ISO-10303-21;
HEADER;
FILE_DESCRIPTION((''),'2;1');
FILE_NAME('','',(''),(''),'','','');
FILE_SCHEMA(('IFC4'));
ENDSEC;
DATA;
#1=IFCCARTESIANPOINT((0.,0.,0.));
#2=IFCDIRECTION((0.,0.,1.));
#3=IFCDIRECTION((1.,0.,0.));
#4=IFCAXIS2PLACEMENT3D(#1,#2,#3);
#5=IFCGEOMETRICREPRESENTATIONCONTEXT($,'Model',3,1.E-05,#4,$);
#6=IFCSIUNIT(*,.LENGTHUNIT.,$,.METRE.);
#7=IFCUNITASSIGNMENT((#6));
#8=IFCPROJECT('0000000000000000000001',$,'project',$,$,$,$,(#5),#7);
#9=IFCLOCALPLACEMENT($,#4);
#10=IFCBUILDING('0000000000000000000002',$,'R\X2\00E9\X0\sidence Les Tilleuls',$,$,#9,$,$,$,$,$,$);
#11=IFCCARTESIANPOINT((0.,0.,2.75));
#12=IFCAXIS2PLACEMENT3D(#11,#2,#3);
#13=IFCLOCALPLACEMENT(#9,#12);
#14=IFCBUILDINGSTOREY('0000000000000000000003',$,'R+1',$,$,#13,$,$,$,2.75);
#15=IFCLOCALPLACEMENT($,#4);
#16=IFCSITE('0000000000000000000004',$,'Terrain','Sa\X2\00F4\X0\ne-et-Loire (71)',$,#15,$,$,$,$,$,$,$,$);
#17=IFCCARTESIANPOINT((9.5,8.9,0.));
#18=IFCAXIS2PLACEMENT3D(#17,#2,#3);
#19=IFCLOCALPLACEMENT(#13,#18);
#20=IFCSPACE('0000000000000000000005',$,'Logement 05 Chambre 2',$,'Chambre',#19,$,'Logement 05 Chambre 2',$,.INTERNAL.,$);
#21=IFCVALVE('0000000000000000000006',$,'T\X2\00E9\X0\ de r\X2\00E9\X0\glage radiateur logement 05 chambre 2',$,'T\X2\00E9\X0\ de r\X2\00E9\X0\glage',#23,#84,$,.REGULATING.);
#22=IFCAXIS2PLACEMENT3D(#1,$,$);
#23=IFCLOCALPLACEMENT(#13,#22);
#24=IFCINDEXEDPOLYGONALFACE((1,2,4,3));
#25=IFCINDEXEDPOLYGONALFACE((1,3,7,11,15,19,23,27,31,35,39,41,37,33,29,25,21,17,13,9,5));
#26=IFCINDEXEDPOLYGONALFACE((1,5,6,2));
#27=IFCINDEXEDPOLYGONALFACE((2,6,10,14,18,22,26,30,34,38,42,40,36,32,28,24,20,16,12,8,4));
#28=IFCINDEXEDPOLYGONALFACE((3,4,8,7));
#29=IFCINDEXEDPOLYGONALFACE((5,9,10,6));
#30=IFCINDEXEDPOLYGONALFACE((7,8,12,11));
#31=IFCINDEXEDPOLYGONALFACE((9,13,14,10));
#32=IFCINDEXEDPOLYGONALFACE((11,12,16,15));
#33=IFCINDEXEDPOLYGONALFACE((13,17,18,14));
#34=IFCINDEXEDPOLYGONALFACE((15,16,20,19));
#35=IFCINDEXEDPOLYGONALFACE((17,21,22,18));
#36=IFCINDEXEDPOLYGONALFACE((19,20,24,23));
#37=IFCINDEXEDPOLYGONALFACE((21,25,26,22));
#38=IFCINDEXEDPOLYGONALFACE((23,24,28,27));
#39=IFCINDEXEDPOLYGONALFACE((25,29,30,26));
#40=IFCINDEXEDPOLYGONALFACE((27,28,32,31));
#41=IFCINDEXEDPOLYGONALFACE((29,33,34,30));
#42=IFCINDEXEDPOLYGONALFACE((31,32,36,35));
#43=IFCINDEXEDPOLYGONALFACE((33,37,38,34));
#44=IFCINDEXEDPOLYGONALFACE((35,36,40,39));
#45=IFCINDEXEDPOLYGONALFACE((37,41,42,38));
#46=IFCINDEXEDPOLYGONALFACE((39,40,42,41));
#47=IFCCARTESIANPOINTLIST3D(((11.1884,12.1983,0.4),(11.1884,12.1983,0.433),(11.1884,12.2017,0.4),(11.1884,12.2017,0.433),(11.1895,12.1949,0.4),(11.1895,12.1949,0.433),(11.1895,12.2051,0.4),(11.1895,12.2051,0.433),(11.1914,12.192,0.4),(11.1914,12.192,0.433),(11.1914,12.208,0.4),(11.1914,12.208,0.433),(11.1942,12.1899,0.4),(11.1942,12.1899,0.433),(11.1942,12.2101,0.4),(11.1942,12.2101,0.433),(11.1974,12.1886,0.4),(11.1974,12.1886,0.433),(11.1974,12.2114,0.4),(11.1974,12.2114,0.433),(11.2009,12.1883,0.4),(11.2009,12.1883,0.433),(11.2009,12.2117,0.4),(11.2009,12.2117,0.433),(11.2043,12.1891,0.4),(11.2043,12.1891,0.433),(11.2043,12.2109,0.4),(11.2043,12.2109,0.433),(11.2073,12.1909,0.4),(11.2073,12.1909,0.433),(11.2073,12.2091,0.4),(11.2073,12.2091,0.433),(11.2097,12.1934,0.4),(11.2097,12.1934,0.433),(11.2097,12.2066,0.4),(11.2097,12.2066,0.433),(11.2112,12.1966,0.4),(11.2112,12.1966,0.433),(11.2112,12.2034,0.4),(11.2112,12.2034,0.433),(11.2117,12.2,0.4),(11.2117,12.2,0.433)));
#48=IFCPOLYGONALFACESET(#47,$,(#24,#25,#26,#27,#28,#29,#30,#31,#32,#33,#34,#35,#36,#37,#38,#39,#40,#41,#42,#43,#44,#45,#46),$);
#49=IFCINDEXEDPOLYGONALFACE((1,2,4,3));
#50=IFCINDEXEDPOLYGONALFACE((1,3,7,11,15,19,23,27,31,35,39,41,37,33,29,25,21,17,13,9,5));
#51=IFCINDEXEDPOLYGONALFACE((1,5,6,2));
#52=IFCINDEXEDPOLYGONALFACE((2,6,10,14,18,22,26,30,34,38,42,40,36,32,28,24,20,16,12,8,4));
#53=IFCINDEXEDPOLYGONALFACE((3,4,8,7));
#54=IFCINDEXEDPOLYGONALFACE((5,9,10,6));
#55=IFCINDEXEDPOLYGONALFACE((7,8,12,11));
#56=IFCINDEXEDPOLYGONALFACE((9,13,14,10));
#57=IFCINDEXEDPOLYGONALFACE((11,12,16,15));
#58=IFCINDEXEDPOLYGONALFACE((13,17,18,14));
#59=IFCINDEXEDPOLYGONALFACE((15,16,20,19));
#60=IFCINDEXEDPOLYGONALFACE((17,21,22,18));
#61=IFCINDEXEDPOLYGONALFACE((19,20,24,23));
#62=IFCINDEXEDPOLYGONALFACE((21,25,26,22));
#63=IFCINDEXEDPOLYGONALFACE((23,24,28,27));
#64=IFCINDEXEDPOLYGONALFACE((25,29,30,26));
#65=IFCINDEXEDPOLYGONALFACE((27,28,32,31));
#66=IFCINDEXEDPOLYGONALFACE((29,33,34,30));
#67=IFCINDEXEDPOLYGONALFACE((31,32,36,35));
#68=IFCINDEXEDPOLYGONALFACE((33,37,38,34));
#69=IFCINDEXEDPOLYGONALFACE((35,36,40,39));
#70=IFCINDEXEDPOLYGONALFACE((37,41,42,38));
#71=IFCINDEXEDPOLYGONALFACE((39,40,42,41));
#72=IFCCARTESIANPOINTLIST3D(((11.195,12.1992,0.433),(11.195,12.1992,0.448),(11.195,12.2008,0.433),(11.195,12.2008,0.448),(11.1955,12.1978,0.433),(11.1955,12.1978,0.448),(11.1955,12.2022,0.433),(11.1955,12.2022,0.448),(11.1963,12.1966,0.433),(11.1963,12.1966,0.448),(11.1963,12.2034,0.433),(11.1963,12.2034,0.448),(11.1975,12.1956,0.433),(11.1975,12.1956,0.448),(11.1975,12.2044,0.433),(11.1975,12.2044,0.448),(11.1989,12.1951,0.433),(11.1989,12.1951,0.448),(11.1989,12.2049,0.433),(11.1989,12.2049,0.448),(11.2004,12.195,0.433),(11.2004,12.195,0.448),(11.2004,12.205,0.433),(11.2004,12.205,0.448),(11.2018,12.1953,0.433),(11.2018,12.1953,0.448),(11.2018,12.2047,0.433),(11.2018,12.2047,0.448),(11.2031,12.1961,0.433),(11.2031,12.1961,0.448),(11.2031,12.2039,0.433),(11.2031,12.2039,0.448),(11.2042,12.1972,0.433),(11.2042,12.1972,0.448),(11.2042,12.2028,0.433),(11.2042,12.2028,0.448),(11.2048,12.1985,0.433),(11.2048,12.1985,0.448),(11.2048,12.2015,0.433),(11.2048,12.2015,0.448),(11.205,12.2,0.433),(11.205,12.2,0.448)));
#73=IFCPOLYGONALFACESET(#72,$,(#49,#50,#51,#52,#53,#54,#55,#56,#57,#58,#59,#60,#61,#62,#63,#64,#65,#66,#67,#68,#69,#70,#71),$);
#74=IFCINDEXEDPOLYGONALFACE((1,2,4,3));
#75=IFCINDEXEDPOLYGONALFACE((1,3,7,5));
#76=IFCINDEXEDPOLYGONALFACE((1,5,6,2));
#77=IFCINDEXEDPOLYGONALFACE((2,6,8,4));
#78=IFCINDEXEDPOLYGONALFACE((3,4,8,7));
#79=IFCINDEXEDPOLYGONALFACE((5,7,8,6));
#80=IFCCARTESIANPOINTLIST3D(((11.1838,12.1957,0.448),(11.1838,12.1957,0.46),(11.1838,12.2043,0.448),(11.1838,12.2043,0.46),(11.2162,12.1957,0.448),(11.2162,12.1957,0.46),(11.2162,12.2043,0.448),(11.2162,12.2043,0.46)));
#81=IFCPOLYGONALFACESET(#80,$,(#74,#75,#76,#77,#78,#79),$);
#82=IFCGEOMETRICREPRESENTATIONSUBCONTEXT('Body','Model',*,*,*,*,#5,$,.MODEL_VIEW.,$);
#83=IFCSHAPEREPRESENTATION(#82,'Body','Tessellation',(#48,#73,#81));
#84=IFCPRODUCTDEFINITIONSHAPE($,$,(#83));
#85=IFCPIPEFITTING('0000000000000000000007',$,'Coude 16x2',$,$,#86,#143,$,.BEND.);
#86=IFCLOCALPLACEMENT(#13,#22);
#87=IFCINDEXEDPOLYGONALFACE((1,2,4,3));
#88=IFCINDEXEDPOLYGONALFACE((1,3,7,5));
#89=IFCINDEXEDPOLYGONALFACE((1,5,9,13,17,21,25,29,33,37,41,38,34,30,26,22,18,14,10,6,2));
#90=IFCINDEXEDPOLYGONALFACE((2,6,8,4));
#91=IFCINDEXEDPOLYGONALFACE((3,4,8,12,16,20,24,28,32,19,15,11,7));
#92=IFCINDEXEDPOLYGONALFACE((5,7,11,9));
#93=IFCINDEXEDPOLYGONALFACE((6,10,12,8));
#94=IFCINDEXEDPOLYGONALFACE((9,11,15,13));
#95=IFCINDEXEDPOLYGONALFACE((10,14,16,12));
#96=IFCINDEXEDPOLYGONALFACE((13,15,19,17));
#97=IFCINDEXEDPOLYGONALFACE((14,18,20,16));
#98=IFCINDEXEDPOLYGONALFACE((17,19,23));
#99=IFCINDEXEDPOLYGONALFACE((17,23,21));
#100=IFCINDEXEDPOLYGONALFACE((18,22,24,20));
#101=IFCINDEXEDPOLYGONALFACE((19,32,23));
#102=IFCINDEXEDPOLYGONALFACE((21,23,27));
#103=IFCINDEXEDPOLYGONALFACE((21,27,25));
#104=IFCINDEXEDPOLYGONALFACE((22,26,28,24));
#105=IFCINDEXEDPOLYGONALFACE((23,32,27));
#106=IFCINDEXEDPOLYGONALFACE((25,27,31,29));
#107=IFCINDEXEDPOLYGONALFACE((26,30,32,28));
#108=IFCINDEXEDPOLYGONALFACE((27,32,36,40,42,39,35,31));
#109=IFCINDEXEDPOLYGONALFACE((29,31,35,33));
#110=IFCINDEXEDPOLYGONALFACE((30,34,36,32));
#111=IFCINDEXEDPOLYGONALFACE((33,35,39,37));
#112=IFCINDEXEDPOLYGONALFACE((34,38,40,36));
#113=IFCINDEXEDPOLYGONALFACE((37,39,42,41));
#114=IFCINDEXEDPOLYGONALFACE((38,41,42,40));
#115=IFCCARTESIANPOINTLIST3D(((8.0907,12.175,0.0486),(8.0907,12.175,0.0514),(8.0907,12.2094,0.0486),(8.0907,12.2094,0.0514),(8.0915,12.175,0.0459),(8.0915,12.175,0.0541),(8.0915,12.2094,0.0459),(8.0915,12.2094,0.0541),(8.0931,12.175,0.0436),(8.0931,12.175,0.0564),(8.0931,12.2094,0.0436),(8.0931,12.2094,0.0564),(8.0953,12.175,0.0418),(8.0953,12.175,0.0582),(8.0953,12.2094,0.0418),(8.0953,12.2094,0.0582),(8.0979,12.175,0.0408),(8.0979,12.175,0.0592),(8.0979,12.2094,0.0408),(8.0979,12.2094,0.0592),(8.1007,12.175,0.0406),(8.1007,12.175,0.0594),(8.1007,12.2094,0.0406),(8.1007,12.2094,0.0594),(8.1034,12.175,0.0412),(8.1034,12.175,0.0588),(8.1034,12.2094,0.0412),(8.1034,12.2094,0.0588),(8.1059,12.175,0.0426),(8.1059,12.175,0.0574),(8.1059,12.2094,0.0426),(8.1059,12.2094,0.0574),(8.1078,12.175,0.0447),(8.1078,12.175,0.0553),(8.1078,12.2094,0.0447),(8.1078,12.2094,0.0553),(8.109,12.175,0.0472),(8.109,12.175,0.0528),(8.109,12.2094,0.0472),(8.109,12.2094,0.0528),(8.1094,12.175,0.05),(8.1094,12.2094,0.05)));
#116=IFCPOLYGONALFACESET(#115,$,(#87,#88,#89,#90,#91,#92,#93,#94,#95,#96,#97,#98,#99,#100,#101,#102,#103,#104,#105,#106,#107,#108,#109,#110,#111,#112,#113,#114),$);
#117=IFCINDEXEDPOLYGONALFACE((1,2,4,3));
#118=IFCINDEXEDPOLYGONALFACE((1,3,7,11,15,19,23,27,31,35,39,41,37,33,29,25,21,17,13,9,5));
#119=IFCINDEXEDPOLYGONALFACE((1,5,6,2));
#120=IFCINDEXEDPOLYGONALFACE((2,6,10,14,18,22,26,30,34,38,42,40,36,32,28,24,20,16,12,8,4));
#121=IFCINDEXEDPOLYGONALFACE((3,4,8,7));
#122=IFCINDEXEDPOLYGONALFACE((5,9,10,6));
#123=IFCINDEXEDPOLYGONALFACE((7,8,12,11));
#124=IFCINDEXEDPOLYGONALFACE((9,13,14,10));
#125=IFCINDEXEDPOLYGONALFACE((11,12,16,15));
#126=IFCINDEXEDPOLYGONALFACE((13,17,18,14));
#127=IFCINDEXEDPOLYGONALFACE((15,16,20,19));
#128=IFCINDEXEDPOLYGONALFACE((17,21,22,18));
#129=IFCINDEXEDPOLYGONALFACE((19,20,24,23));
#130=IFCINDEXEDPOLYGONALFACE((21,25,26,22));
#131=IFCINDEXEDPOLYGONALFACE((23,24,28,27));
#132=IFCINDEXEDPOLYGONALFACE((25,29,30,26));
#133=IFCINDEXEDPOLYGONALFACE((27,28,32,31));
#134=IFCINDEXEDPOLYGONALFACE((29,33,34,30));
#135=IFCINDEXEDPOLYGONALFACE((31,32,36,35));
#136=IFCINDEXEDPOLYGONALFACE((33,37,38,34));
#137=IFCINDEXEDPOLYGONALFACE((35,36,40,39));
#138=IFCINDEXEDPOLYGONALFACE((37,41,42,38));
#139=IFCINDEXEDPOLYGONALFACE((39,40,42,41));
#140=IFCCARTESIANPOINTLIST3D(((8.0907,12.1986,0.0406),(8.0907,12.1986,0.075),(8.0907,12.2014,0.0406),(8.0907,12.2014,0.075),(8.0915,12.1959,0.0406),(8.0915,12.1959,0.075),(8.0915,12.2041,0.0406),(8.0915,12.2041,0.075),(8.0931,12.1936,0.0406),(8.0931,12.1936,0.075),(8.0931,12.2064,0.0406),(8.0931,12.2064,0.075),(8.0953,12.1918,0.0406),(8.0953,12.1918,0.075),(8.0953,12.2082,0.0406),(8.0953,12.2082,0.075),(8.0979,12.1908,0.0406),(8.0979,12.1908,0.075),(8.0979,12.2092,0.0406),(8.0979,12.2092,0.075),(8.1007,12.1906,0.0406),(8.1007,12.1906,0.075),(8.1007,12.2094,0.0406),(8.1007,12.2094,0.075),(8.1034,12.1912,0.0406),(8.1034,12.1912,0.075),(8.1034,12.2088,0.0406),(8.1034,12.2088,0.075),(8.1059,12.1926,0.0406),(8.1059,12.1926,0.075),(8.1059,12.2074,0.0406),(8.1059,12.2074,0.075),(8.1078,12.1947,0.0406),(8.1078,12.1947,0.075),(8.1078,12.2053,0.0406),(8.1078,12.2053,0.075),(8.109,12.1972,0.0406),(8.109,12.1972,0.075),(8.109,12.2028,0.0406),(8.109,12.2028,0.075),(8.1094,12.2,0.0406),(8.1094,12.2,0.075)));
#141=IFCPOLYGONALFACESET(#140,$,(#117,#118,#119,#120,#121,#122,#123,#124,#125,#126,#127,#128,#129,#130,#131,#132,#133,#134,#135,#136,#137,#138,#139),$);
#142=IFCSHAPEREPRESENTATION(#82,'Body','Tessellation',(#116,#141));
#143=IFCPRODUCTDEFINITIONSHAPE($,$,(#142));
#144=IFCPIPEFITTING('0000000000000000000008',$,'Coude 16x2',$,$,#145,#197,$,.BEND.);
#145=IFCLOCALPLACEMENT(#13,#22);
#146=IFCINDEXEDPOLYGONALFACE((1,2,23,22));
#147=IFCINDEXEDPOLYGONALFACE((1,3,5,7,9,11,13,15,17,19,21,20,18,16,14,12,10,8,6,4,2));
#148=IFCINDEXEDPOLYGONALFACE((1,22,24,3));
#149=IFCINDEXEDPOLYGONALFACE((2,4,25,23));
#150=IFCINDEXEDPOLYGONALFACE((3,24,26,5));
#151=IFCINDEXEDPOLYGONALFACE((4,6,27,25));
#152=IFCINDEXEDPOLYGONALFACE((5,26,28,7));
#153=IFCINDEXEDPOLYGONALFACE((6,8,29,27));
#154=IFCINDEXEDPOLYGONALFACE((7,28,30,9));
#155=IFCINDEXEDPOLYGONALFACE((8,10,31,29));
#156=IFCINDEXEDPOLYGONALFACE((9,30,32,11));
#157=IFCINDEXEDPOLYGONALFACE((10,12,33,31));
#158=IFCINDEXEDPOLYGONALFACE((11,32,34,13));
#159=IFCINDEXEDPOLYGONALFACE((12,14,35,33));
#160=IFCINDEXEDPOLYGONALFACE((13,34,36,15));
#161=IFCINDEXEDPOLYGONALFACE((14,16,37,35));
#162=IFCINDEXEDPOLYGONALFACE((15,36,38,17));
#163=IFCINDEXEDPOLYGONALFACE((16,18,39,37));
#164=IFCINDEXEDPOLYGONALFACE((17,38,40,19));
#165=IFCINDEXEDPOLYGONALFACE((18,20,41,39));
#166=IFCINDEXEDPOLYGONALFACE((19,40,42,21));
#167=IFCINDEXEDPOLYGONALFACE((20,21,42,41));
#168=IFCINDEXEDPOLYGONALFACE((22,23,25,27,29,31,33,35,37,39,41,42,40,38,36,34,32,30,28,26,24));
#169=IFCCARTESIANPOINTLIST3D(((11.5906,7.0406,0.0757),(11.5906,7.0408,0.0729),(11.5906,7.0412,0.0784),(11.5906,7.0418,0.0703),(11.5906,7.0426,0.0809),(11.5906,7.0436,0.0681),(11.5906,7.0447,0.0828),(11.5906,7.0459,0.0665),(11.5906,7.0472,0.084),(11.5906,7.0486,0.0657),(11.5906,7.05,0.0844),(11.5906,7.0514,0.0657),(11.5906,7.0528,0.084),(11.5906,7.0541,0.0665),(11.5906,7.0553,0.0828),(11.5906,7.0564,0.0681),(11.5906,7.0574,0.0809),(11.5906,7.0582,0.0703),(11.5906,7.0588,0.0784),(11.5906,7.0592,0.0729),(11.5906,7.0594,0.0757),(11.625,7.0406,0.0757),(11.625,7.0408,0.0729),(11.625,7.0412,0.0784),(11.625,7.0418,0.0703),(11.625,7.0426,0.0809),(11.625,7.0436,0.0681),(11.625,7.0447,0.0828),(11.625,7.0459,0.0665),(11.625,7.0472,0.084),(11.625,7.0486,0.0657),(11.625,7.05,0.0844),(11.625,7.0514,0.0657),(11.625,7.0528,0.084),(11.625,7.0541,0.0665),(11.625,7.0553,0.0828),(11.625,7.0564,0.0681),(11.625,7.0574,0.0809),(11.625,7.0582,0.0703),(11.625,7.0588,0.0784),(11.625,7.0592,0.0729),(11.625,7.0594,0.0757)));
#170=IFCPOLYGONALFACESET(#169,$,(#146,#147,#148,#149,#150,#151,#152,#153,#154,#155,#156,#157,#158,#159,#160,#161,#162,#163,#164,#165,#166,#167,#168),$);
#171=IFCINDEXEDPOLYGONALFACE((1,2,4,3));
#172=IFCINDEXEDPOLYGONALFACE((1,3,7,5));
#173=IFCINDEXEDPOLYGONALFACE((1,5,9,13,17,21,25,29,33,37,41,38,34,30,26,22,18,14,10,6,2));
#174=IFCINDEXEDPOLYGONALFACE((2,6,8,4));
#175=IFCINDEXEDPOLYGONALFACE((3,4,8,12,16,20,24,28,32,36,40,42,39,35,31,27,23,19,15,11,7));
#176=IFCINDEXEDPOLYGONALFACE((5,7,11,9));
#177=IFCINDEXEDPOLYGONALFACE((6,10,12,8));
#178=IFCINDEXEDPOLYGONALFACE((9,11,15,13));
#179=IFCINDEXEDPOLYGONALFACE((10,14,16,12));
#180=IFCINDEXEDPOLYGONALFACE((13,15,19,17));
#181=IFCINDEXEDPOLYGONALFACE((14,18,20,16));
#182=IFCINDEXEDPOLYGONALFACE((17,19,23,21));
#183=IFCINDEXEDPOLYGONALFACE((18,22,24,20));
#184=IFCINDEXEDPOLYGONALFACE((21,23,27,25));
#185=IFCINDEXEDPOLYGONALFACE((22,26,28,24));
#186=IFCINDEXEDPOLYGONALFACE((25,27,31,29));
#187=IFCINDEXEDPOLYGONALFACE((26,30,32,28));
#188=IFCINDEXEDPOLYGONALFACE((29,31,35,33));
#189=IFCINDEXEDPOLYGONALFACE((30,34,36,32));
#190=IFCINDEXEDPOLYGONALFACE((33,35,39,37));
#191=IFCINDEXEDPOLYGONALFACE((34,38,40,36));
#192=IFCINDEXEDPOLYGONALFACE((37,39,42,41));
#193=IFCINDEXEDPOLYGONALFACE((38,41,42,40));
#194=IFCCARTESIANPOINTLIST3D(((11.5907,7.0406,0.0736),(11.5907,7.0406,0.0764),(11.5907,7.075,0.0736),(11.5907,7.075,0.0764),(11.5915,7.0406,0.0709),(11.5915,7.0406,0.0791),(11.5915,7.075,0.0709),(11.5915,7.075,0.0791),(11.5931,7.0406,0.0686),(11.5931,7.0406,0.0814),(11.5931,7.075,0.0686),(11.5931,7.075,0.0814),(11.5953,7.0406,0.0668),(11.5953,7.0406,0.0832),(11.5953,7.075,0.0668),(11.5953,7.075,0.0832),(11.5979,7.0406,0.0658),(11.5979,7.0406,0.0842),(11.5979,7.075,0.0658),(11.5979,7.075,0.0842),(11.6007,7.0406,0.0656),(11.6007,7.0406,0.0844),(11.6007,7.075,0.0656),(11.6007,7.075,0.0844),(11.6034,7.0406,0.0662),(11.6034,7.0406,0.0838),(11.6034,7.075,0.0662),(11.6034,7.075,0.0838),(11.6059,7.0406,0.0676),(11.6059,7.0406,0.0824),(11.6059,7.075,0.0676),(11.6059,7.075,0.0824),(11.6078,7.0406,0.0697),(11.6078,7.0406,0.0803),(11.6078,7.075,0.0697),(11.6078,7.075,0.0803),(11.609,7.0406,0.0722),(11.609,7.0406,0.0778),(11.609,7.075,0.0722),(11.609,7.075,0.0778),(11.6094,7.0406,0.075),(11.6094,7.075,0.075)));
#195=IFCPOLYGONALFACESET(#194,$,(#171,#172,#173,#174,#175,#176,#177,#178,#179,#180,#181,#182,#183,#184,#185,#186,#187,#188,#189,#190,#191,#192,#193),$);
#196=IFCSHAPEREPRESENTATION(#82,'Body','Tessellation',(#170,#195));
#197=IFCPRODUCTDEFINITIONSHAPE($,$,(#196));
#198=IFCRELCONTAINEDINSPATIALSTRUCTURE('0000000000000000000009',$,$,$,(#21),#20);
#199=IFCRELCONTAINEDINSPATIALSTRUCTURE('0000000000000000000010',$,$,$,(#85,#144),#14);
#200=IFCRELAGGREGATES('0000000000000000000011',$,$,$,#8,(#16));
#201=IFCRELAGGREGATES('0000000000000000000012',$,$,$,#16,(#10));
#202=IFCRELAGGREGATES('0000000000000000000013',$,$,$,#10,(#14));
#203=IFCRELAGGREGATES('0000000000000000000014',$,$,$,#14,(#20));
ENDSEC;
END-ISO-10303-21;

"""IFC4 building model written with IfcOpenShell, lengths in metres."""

from ifc_helpers import new_model, si_unit, frame, frame_2d, origin_with_axes, place, context, subcontext, project, spatial, rectangle, circle, extrude, element, save


model = new_model("IFC4")

# Units and contexts
model_context = context("Model", 3, precision=1e-05, world=origin_with_axes())
body_context = subcontext(model_context, "Body", "Model", "MODEL_VIEW")
ifc_project = project(units=[si_unit("LENGTHUNIT", "METRE")], contexts=[model_context])

# Site, building, storey
site_placement = place(None, origin_with_axes())
site = spatial("IfcSite", under=ifc_project, at=site_placement, Name="Terrain", Description="Saône-et-Loire (71)")
building_placement = place(None, origin_with_axes())
building = spatial("IfcBuilding", under=site, at=building_placement, Name="Résidence Les Tilleuls")
storey_placement = place(building_placement, frame((0.0, 0.0, 2.75), z_axis=(0.0, 0.0, 1.0), x_axis=(1.0, 0.0, 0.0)))
storey = spatial("IfcBuildingStorey", under=building, at=storey_placement, Name="R+1", Elevation=2.75)

# Shared definitions
space_1_placement = place(storey_placement, frame((9.5, 8.9, 0.0), z_axis=(0.0, 0.0, 1.0), x_axis=(1.0, 0.0, 0.0)))
space_1 = spatial("IfcSpace", under=storey, at=space_1_placement, Name="Logement 05 Chambre 2", ObjectType="Chambre", LongName="Logement 05 Chambre 2", PredefinedType="INTERNAL")

# Valve
valve_1_placement = place(space_1_placement, frame((1.7, 3.3, 0.4), z_axis=(0.0, 0.0, 1.0), x_axis=(1.0, 0.0, 0.0)))
element("IfcValve", 1, at=valve_1_placement, inside=space_1, Name="Té de réglage radiateur logement 05 chambre 2", ObjectType="Té de réglage", PredefinedType="REGULATING", context=body_context, shape_type="SweptSolid", body=[
    extrude(circle(Radius=0.0117), origin_with_axes(), (0.0, 0.0, 1.0), 0.033),
    extrude(circle(Radius=0.005), frame((0.0, 0.0, 0.033), z_axis=(0.0, 0.0, 1.0), x_axis=(1.0, 0.0, 0.0)), (0.0, 0.0, 1.0), 0.015),
    extrude(rectangle(XDim=0.0324, YDim=0.0086, at=frame_2d((0.0162, 0.0043))), frame((-0.0162, -0.0043, 0.048), z_axis=(0.0, 0.0, 1.0), x_axis=(1.0, 0.0, 0.0)), (0.0, 0.0, 1.0), 0.012),
])

# Pipe fittings
pipe_fitting_1_placement = place(storey_placement, frame((8.1, 12.2, 0.05), z_axis=(0.0, 0.0, 1.0), x_axis=(1.0, 0.0, 0.0)))
element("IfcPipeFitting", 2, at=pipe_fitting_1_placement, inside=storey, Name="Coude 16x2", PredefinedType="BEND", context=body_context, shape_type="SweptSolid", body=[
    extrude(circle(Radius=0.0094), frame((0.0, 0.0094, 0.0), z_axis=(0.0, -1.0, 0.0), x_axis=(1.0, 0.0, 0.0)), (0.0, 0.0, 1.0), 0.0344),
    extrude(circle(Radius=0.0094), frame((0.0, 0.0, -0.0094), z_axis=(0.0, 0.0, 1.0), x_axis=(1.0, 0.0, 0.0)), (0.0, 0.0, 1.0), 0.0344),
])
pipe_fitting_2_placement = place(storey_placement, frame((11.6, 7.05, 0.075), z_axis=(0.0, 0.0, 1.0), x_axis=(1.0, 0.0, 0.0)))
element("IfcPipeFitting", 3, at=pipe_fitting_2_placement, inside=storey, Name="Coude 16x2", PredefinedType="BEND", context=body_context, shape_type="SweptSolid", body=[
    extrude(circle(Radius=0.0094), frame((-0.0094, 0.0, 0.0), z_axis=(1.0, 0.0, 0.0), x_axis=(0.0, 0.0, 1.0)), (0.0, 0.0, 1.0), 0.0344),
    extrude(circle(Radius=0.0094), frame((0.0, -0.0094, 0.0), z_axis=(0.0, 1.0, 0.0), x_axis=(1.0, 0.0, 0.0)), (0.0, 0.0, 1.0), 0.0344),
])

save(model, "model.ifc")
